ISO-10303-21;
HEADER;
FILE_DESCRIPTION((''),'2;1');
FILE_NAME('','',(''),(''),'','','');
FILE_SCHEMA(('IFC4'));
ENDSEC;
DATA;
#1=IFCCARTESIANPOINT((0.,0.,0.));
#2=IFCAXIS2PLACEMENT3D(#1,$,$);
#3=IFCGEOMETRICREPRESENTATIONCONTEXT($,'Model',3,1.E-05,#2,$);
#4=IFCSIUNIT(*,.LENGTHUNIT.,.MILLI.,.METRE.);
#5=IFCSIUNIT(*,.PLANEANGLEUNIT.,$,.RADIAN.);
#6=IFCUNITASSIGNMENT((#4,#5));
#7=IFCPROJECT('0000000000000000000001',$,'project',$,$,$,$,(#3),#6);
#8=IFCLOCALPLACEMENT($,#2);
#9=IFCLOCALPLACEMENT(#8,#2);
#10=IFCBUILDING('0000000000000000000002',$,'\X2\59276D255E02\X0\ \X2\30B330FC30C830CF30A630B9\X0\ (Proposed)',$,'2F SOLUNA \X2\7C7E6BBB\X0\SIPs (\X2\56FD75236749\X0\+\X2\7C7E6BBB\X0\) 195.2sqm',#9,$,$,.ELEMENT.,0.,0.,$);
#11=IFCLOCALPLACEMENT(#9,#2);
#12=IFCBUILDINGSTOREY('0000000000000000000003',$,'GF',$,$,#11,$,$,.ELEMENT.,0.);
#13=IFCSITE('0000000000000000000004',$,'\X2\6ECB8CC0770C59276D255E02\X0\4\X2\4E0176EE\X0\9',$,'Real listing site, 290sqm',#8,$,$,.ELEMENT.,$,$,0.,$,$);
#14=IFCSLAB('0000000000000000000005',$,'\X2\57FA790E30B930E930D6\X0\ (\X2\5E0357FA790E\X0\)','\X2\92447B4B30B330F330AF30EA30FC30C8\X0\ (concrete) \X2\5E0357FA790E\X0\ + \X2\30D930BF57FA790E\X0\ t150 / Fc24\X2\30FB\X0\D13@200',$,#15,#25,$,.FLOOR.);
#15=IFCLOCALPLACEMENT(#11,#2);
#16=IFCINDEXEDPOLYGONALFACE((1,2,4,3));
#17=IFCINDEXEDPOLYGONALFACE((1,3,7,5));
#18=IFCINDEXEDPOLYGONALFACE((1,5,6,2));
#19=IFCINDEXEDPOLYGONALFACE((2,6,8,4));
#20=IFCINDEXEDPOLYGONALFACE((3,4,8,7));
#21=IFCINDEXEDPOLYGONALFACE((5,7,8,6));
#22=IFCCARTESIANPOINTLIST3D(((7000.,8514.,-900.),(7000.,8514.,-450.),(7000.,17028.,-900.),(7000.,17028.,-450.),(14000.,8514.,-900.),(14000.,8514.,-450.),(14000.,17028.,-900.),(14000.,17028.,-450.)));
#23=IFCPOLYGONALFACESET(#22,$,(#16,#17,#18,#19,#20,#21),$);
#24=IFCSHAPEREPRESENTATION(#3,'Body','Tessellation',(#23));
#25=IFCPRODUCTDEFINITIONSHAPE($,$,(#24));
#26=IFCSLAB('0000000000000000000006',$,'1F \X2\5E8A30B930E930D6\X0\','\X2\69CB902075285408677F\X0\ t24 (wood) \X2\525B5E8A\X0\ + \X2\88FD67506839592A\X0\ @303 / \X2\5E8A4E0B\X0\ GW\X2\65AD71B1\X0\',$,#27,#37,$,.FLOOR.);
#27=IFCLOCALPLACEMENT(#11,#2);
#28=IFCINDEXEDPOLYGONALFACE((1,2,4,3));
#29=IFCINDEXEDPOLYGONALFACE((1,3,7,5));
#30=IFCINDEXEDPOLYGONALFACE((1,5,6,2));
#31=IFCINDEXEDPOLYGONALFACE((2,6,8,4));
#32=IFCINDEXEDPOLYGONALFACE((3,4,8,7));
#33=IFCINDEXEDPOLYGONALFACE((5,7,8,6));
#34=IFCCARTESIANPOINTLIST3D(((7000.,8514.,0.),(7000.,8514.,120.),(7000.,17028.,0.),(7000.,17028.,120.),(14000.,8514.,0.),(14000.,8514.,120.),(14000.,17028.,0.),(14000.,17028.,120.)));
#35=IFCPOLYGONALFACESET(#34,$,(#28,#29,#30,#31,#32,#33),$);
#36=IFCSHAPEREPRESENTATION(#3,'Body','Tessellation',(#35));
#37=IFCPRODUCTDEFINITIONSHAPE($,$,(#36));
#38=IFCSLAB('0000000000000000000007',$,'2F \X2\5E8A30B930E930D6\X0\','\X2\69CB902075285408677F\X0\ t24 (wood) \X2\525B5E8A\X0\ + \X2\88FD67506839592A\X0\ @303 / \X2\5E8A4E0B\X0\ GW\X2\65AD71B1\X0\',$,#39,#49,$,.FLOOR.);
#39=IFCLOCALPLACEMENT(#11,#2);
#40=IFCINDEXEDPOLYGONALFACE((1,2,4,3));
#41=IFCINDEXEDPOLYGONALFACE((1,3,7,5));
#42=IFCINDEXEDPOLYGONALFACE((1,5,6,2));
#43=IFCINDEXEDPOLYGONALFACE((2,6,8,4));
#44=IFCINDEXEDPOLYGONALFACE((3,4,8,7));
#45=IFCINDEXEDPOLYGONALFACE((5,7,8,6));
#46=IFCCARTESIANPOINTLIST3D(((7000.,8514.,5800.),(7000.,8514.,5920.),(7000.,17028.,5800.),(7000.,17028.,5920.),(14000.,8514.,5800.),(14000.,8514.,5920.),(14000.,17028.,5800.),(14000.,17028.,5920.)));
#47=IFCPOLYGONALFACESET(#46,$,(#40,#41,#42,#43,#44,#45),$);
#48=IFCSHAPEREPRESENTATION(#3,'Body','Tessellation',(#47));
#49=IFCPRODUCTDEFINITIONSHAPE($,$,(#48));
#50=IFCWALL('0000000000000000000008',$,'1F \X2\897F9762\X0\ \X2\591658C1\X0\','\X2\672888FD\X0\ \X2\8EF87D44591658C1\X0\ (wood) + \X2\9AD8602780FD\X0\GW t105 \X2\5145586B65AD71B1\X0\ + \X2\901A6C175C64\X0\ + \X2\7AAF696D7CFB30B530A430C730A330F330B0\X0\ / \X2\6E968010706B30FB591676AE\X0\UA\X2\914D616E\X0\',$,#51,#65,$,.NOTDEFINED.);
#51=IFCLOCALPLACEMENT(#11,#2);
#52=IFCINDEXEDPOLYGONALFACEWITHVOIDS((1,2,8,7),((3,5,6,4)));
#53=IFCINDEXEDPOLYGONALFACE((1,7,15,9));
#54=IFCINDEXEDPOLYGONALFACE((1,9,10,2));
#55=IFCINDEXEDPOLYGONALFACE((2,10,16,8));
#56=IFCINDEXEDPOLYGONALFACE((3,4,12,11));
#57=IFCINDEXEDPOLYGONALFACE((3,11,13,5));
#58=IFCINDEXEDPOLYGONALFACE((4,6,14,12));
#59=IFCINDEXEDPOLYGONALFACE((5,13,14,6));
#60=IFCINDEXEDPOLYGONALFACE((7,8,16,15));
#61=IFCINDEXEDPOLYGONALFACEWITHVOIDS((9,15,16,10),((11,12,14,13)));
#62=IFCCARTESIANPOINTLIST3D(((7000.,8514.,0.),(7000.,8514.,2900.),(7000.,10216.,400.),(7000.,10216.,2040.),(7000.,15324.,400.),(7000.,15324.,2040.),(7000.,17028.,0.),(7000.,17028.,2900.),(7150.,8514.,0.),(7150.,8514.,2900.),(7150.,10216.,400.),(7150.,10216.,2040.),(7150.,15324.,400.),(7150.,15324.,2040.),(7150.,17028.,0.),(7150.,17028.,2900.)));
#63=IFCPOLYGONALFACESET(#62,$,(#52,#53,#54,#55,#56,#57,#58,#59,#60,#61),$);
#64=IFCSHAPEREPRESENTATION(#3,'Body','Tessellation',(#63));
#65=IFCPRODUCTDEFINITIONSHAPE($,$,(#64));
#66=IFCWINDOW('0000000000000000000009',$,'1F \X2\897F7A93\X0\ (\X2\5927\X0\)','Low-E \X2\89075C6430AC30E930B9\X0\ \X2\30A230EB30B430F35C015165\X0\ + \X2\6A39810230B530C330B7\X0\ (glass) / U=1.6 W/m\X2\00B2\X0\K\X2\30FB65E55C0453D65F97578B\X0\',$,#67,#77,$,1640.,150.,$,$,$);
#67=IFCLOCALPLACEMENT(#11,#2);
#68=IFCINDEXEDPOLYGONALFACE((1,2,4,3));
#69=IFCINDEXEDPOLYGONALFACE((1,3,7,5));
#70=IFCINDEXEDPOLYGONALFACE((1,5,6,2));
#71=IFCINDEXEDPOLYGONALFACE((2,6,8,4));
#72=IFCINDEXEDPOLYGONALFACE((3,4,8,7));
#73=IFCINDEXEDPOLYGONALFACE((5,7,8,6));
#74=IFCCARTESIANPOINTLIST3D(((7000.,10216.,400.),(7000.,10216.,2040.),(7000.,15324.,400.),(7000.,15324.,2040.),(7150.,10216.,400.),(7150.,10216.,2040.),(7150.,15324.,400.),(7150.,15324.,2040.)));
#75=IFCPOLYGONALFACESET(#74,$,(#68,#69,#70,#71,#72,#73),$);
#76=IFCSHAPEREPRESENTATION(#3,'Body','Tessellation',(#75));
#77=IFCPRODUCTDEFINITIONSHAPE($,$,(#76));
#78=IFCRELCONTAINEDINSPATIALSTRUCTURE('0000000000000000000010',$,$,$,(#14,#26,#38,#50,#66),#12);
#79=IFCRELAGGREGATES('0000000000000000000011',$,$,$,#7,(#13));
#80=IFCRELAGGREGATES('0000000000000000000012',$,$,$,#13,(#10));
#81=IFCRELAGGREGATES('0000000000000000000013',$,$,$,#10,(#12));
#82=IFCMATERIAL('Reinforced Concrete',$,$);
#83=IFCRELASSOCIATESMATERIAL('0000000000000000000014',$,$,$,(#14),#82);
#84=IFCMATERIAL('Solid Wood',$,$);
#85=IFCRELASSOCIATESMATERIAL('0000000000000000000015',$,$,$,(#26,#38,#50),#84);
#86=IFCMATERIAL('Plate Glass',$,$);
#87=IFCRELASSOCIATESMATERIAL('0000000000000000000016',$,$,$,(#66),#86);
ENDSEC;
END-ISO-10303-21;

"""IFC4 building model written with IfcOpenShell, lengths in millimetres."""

from ifc_helpers import new_model, si_unit, frame, frame_2d, origin, place, context, project, spatial, rectangle, extrude, material, element, fill, save


model = new_model("IFC4")

# Units and contexts
model_context = context("Model", 3, precision=1e-05, world=origin())
ifc_project = project(units=[si_unit("LENGTHUNIT", "METRE", prefix="MILLI"), si_unit("PLANEANGLEUNIT", "RADIAN")], contexts=[model_context])

# Site, building, storey
site_placement = place(None, origin())
site = spatial("IfcSite", under=ifc_project, at=site_placement, Name="滋賀県大津市4丁目9", ObjectType="Real listing site, 290sqm", CompositionType="ELEMENT", RefElevation=0.0)
building_placement = place(site_placement, origin())
building = spatial("IfcBuilding", under=site, at=building_placement, Name="大津市 コートハウス (Proposed)", ObjectType="2F SOLUNA 籾殻SIPs (国産杉+籾殻) 195.2sqm", CompositionType="ELEMENT", ElevationOfRefHeight=0.0, ElevationOfTerrain=0.0)
storey_placement = place(building_placement, origin())
storey = spatial("IfcBuildingStorey", under=building, at=storey_placement, Name="GF", CompositionType="ELEMENT", Elevation=0.0)

# Slabs
ifc_material_1 = material(Name="Reinforced Concrete")
slab_1_placement = place(storey_placement, frame((3500.0, 4257.0, -450.0)))
element("IfcSlab", 1, at=slab_1_placement, inside=storey, material=ifc_material_1, Name="基礎スラブ (布基礎)", Description="鉄筋コンクリート (concrete) 布基礎 + ベタ基礎 t150 / Fc24・D13@200", PredefinedType="FLOOR", context=model_context, shape_type="SweptSolid", body=[
    extrude(rectangle(XDim=7000.0, YDim=8514.0, at=frame_2d((3500.0, 4257.0))), frame((3500.0, 4257.0, -450.0)), (0.0, 0.0, 1.0), 450.0),
])
ifc_material_2 = material(Name="Solid Wood")
slab_2_placement = place(storey_placement, frame((3500.0, 4257.0, 0.0)))
element("IfcSlab", 2, at=slab_2_placement, inside=storey, material=ifc_material_2, Name="1F 床スラブ", Description="構造用合板 t24 (wood) 剛床 + 製材根太 @303 / 床下 GW断熱", PredefinedType="FLOOR", context=model_context, shape_type="SweptSolid", body=[
    extrude(rectangle(XDim=7000.0, YDim=8514.0, at=frame_2d((3500.0, 4257.0))), frame((3500.0, 4257.0, 0.0)), (0.0, 0.0, 1.0), 120.0),
])
slab_3_placement = place(storey_placement, frame((3500.0, 4257.0, 2900.0)))
element("IfcSlab", 3, at=slab_3_placement, inside=storey, material=ifc_material_2, Name="2F 床スラブ", Description="構造用合板 t24 (wood) 剛床 + 製材根太 @303 / 床下 GW断熱", PredefinedType="FLOOR", context=model_context, shape_type="SweptSolid", body=[
    extrude(rectangle(XDim=7000.0, YDim=8514.0, at=frame_2d((3500.0, 4257.0))), frame((3500.0, 4257.0, 2900.0)), (0.0, 0.0, 1.0), 120.0),
])

# Shared definitions
ifc_material_3 = material(Name="Plate Glass")

# Wall, opening, window
wall_1_placement = place(storey_placement, frame((3500.0, 4257.0, 0.0)))
wall_1 = element("IfcWall", 4, at=wall_1_placement, inside=storey, material=ifc_material_2, Name="1F 西面 外壁", Description="木製 軸組外壁 (wood) + 高性能GW t105 充填断熱 + 通気層 + 窯業系サイディング / 準耐火・外皮UA配慮", PredefinedType="NOTDEFINED", context=model_context, shape_type="SweptSolid", body=[
    extrude(rectangle(XDim=150.0, YDim=8514.0, at=frame_2d((75.0, 4257.0))), frame((3500.0, 4257.0, 0.0)), (0.0, 0.0, 1.0), 2900.0),
])
opening_1_placement = place(storey_placement, frame((3500.0, 5108.0, 200.0)))
opening_1 = element("IfcOpeningElement", 5, at=opening_1_placement, cuts=wall_1, PredefinedType="NOTDEFINED", context=model_context, shape_type="SweptSolid", body=[
    extrude(rectangle(XDim=150.0, YDim=5108.0, at=frame_2d((75.0, 2554.0))), frame((3500.0, 5108.0, 200.0)), (0.0, 0.0, 1.0), 1640.0),
])
window_1_placement = place(storey_placement, frame((3500.0, 5108.0, 200.0)))
window_1 = element("IfcWindow", 6, at=window_1_placement, inside=storey, material=ifc_material_3, Name="1F 西窓 (大)", Description="Low-E 複層ガラス アルゴン封入 + 樹脂サッシ (glass) / U=1.6 W/m²K・日射取得型", OverallHeight=1640.0, OverallWidth=150.0, context=model_context, shape_type="SweptSolid", body=[
    extrude(rectangle(XDim=150.0, YDim=5108.0, at=frame_2d((75.0, 2554.0))), frame((3500.0, 5108.0, 200.0)), (0.0, 0.0, 1.0), 1640.0),
])
fill(opening_1, window_1)

save(model, "model.ifc")
